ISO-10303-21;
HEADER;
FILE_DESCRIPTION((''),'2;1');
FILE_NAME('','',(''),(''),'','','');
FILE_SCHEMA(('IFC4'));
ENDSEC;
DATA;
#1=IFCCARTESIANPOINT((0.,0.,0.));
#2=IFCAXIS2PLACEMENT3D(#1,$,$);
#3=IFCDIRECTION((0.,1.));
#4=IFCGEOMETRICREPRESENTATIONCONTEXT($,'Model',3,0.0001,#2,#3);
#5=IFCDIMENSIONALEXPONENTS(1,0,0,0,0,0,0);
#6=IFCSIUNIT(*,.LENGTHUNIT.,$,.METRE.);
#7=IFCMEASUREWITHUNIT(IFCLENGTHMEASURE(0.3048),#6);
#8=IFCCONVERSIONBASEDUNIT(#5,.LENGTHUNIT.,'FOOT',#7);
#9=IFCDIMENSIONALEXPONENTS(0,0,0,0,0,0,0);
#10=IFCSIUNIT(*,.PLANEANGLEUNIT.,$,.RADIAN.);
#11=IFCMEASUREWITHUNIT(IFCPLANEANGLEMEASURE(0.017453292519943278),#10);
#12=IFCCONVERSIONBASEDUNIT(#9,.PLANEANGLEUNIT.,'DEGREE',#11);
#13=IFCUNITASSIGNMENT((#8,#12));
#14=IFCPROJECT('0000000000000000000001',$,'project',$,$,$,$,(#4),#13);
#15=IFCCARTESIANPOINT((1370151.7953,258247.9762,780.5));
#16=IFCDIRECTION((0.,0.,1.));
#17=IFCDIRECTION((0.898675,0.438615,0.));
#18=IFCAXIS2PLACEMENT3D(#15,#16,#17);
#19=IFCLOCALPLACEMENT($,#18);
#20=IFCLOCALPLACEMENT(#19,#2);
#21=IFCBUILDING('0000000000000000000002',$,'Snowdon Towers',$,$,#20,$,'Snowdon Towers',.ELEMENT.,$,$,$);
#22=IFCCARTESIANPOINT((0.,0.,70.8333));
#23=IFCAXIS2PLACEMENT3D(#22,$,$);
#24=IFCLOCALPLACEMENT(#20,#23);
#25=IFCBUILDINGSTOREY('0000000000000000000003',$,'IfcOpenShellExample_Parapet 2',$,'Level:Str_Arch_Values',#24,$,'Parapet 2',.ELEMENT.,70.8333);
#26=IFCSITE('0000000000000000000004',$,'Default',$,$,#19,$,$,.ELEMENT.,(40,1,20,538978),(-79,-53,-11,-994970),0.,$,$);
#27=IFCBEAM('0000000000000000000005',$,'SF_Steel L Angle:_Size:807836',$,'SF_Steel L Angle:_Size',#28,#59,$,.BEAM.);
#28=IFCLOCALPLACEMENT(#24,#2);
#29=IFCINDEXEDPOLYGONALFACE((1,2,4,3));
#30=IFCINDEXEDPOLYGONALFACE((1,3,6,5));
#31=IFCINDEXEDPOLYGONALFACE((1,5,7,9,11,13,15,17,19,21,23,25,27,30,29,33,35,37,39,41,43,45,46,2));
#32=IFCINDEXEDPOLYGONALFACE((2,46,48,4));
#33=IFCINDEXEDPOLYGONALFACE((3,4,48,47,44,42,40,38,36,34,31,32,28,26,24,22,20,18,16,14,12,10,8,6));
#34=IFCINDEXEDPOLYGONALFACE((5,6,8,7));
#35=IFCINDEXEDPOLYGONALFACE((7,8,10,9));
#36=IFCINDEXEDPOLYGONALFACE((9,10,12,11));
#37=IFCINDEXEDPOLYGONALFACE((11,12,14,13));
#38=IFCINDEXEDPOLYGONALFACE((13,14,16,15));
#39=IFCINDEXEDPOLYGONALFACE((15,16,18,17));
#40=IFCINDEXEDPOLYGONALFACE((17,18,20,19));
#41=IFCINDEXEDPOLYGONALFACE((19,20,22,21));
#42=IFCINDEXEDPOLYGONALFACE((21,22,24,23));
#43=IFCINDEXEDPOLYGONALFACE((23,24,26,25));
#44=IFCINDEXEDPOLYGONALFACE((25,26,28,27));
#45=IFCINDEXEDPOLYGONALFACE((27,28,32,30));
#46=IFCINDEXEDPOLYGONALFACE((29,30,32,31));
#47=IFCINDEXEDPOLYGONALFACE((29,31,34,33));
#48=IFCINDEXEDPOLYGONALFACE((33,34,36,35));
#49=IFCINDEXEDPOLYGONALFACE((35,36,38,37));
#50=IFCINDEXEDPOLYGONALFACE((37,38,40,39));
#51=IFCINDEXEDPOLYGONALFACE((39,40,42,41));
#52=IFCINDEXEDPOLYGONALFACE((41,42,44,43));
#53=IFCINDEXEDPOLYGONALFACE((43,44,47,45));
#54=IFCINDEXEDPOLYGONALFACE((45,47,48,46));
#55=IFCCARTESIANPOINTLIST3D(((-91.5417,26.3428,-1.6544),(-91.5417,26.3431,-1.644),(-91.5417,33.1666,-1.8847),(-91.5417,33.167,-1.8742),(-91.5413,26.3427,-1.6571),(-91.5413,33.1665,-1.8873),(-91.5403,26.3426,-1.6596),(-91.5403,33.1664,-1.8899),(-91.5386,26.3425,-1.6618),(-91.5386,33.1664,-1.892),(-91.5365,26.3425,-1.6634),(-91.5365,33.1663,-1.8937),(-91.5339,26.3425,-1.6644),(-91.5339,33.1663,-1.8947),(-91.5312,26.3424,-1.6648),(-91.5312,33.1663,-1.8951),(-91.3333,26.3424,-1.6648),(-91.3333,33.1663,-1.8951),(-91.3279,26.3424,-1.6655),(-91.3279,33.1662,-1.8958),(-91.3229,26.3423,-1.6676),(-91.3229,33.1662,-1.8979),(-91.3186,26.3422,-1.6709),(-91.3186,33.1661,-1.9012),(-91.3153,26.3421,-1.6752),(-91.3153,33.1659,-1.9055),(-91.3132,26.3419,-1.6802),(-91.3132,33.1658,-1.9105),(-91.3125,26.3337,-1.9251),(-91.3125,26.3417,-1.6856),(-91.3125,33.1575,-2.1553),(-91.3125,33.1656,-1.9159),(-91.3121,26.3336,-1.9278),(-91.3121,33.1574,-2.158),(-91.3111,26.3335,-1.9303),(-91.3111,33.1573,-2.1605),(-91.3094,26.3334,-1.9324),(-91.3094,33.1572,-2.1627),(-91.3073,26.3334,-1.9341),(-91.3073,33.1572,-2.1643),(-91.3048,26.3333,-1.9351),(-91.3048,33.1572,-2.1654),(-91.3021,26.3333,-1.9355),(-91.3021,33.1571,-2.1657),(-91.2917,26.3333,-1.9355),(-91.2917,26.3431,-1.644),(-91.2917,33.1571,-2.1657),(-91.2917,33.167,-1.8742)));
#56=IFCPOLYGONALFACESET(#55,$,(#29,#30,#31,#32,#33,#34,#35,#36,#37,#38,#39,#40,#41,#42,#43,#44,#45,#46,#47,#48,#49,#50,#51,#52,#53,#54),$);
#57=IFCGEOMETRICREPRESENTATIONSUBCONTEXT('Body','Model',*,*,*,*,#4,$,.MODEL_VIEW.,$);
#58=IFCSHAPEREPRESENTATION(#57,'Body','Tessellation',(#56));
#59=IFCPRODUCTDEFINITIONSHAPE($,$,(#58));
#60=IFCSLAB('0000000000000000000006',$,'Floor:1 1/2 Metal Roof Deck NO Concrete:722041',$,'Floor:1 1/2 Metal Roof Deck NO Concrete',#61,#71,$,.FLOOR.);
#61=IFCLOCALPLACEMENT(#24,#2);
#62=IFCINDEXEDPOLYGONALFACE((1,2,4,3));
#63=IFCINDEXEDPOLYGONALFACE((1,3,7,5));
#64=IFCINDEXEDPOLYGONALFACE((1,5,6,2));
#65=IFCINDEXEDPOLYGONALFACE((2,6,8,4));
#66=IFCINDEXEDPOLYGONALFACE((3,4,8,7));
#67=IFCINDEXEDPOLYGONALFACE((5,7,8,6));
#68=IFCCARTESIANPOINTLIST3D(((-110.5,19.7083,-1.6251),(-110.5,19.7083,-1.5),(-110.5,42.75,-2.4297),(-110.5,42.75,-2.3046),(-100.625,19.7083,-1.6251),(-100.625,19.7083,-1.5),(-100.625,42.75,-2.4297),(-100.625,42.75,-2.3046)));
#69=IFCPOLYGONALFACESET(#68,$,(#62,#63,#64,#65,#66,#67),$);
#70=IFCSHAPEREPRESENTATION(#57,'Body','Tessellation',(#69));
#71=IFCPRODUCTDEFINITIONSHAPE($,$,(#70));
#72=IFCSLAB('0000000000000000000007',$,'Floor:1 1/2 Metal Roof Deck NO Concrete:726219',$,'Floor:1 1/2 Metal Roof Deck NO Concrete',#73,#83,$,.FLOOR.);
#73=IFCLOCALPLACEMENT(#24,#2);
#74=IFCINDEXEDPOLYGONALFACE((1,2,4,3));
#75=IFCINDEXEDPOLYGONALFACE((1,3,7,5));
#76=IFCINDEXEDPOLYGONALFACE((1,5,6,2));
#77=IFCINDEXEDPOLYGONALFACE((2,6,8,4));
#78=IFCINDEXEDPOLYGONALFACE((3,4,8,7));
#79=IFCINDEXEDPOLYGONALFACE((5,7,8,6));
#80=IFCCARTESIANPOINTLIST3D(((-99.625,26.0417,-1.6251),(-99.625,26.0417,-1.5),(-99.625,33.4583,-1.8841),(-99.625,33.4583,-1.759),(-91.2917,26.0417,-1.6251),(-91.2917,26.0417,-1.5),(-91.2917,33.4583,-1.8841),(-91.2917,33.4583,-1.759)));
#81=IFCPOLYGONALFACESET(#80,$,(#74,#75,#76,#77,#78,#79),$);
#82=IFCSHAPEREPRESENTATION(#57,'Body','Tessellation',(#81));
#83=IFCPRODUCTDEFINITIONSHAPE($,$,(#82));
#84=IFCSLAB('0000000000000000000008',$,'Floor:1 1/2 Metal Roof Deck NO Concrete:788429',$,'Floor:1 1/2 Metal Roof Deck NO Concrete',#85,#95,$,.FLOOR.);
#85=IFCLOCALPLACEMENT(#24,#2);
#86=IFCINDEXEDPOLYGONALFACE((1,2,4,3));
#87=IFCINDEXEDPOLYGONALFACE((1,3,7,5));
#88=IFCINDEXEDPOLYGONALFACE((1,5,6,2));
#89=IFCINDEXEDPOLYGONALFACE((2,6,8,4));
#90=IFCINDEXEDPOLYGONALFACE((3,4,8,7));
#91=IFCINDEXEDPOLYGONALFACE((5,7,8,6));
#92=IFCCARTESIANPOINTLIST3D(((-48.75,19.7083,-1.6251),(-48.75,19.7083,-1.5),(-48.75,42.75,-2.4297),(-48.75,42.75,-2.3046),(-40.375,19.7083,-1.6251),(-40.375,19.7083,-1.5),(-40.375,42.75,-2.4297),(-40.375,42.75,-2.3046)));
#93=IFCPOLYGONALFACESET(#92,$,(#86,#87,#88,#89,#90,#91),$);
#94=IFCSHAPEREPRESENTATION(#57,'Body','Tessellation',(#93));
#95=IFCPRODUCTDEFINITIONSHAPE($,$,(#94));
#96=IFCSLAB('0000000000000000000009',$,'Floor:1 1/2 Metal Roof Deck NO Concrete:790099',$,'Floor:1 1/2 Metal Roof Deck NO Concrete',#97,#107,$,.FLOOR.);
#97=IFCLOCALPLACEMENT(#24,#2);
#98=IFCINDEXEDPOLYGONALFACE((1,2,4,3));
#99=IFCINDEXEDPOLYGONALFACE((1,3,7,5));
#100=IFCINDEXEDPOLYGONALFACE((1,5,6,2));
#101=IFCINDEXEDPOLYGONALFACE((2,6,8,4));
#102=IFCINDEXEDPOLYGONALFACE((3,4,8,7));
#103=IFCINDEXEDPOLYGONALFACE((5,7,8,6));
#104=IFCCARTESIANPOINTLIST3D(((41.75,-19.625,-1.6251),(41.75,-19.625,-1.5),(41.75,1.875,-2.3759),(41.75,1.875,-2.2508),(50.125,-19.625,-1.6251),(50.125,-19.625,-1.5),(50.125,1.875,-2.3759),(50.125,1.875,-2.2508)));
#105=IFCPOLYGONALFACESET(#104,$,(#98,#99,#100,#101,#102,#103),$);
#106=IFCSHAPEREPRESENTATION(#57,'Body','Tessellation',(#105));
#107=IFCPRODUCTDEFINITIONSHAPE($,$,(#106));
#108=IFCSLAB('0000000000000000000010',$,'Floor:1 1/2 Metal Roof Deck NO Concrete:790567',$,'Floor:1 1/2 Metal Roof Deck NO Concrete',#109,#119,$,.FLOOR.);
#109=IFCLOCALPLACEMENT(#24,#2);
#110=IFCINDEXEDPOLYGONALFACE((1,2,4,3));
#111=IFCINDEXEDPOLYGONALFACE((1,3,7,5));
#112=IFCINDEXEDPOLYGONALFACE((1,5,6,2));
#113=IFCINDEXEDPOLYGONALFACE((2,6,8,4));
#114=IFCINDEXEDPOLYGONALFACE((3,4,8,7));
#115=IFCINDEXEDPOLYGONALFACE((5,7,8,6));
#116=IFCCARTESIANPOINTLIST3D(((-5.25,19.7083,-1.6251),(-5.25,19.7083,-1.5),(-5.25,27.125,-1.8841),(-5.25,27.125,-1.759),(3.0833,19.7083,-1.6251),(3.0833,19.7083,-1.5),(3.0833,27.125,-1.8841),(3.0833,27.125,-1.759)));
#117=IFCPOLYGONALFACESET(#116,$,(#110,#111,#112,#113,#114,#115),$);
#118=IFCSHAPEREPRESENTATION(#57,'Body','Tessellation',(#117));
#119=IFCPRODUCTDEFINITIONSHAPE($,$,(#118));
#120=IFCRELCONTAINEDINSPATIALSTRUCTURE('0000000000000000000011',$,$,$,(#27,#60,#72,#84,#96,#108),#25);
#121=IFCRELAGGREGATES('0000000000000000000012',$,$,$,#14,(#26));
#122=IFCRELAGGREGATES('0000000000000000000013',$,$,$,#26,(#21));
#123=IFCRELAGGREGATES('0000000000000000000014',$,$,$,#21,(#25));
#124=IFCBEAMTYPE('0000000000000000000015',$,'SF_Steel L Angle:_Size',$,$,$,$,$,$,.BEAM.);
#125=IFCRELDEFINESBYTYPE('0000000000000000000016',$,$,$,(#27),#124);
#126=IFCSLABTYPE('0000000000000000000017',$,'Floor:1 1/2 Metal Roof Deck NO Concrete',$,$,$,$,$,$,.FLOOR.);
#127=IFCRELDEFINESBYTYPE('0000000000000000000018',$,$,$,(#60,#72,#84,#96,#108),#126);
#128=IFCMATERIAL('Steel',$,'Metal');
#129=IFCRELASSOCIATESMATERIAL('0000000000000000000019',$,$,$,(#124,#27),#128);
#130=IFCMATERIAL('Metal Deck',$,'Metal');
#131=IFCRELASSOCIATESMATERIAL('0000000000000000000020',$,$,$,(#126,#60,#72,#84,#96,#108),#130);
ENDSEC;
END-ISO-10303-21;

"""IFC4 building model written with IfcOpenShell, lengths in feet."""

from ifc_helpers import new_model, entity, si_unit, converted_unit, direction, frame, frame_2d, origin, place, context, subcontext, project, spatial, line, arc, indexed_curve, rectangle, outline, extrude, source, transform, mapped, material, type_object, type_shapes, element, save


model = new_model("IFC4")

# Units and contexts
model_context = context("Model", 3, precision=0.0001, world=origin(), true_north=direction((0.0, 1.0)))
body_context = subcontext(model_context, "Body", "Model", "MODEL_VIEW")
ifc_project = project(units=[converted_unit("LENGTHUNIT", "FOOT", entity("IfcLengthMeasure", 0.3048), si_unit("LENGTHUNIT", "METRE"), dimensions=[1, 0, 0, 0, 0, 0, 0]), converted_unit("PLANEANGLEUNIT", "DEGREE", entity("IfcPlaneAngleMeasure", 0.017453292519943278), si_unit("PLANEANGLEUNIT", "RADIAN"), dimensions=[0, 0, 0, 0, 0, 0, 0])], contexts=[model_context])

# Site, building, storey
site_placement = place(None, frame((1370151.7953, 258247.9762, 780.5), z_axis=(0.0, 0.0, 1.0), x_axis=(0.898675, 0.438615, 0.0)))
site = spatial("IfcSite", under=ifc_project, at=site_placement, Name="Default", CompositionType="ELEMENT", RefLatitude=(40, 1, 20, 538978), RefLongitude=(-79, -53, -11, -994970), RefElevation=0.0)
building_placement = place(site_placement, origin())
building = spatial("IfcBuilding", under=site, at=building_placement, Name="Snowdon Towers", LongName="Snowdon Towers", CompositionType="ELEMENT")
storey_placement = place(building_placement, frame((0.0, 0.0, 70.8333)))
storey = spatial("IfcBuildingStorey", under=building, at=storey_placement, Name="IfcOpenShellExample_Parapet 2", ObjectType="Level:Str_Arch_Values", LongName="Parapet 2", CompositionType="ELEMENT", Elevation=70.8333)

# Beam
ifc_material_1 = material(Name="Steel", Category="Metal")
beam_type_1 = type_object("IfcBeamType", Name="SF_Steel L Angle:_Size", PredefinedType="BEAM", material=ifc_material_1)
shared_shape_1 = source(origin(), body_context, "Body", "SweptSolid", [
    extrude(outline(indexed_curve([(-0.0926, -0.1065), (0.1574, -0.1065), (0.1574, -0.0961), (0.1544, -0.0887), (0.147, -0.0856), (-0.0509, -0.0856), (-0.0657, -0.0795), (-0.0718, -0.0648), (-0.0718, 0.1748), (-0.0748, 0.1821), (-0.0822, 0.1852), (-0.0926, 0.1852)], segments=[line(1, 2, 3), arc(3, 4, 5), line(5, 6), arc(6, 7, 8), line(8, 9), arc(9, 10, 11), line(11, 12, 1)], self_intersect=False)), frame((-3.4189, -0.0926, -0.1065), z_axis=(1.0, 0.0, 0.0), x_axis=(0.0, -1.0, 0.0)), (0.0, 0.0, 1.0), 6.8277),
])
type_shapes(beam_type_1, [shared_shape_1])
beam_1_placement = place(storey_placement, frame((-91.2917, 29.75, -1.7589), z_axis=(0.0, 0.033724, 0.999431), x_axis=(0.0, -0.999431, 0.033724)))
element("IfcBeam", 1, at=beam_1_placement, inside=storey, type_object=beam_type_1, material=ifc_material_1, Name="SF_Steel L Angle:_Size:807836", ObjectType="SF_Steel L Angle:_Size", PredefinedType="BEAM", context=body_context, shape_type="MappedRepresentation", body=[
    mapped(shared_shape_1, transform((0.0, 0.0, 0.0), scale=1.0)),
])

# Slabs
ifc_material_2 = material(Name="Metal Deck", Category="Metal")
slab_type = type_object("IfcSlabType", Name="Floor:1 1/2 Metal Roof Deck NO Concrete", PredefinedType="FLOOR", material=ifc_material_2)
slab_1_placement = place(storey_placement, frame((-110.5, 19.7083, -2.4297)))
element("IfcSlab", 2, at=slab_1_placement, inside=storey, type_object=slab_type, material=ifc_material_2, Name="Floor:1 1/2 Metal Roof Deck NO Concrete:722041", ObjectType="Floor:1 1/2 Metal Roof Deck NO Concrete", PredefinedType="FLOOR", context=body_context, shape_type="SweptSolid", body=[
    extrude(rectangle(XDim=23.0557, YDim=9.875, at=frame_2d((-4.9375, 11.5279), x_axis=(0.0, 1.0))), frame((9.875, 0.0, 0.9297), z_axis=(0.0, 0.034899, 0.999391), x_axis=(1.0, 0.0, 0.0)), (0.0, 0.034899, -0.999391), 0.1251),
])
slab_2_placement = place(storey_placement, frame((-99.625, 26.0417, -1.8841)))
element("IfcSlab", 3, at=slab_2_placement, inside=storey, type_object=slab_type, material=ifc_material_2, Name="Floor:1 1/2 Metal Roof Deck NO Concrete:726219", ObjectType="Floor:1 1/2 Metal Roof Deck NO Concrete", PredefinedType="FLOOR", context=body_context, shape_type="SweptSolid", body=[
    extrude(rectangle(XDim=7.4212, YDim=8.3333, at=frame_2d((-4.1667, 3.7106), x_axis=(0.0, -1.0))), frame((8.3333, 0.0, 0.3841), z_axis=(0.0, 0.034899, 0.999391), x_axis=(1.0, 0.0, 0.0)), (0.0, 0.034899, -0.999391), 0.1251),
])
slab_3_placement = place(storey_placement, frame((-48.75, 19.7083, -2.4297)))
element("IfcSlab", 4, at=slab_3_placement, inside=storey, type_object=slab_type, material=ifc_material_2, Name="Floor:1 1/2 Metal Roof Deck NO Concrete:788429", ObjectType="Floor:1 1/2 Metal Roof Deck NO Concrete", PredefinedType="FLOOR", context=body_context, shape_type="SweptSolid", body=[
    extrude(rectangle(XDim=8.375, YDim=23.0557, at=frame_2d((-4.1875, 11.5279), x_axis=(1.0, 0.0))), frame((8.375, 0.0, 0.9297), z_axis=(0.0, 0.034899, 0.999391), x_axis=(1.0, 0.0, 0.0)), (0.0, 0.034899, -0.999391), 0.1251),
])
slab_4_placement = place(storey_placement, frame((41.75, -19.625, -2.3759)))
element("IfcSlab", 5, at=slab_4_placement, inside=storey, type_object=slab_type, material=ifc_material_2, Name="Floor:1 1/2 Metal Roof Deck NO Concrete:790099", ObjectType="Floor:1 1/2 Metal Roof Deck NO Concrete", PredefinedType="FLOOR", context=body_context, shape_type="SweptSolid", body=[
    extrude(rectangle(XDim=8.375, YDim=21.5131, at=frame_2d((-4.1875, 10.7566), x_axis=(1.0, 0.0))), frame((8.375, 0.0, 0.8759), z_axis=(0.0, 0.034899, 0.999391), x_axis=(1.0, 0.0, 0.0)), (0.0, 0.034899, -0.999391), 0.1251),
])
slab_5_placement = place(storey_placement, frame((-5.25, 19.7083, -1.8841)))
element("IfcSlab", 6, at=slab_5_placement, inside=storey, type_object=slab_type, material=ifc_material_2, Name="Floor:1 1/2 Metal Roof Deck NO Concrete:790567", ObjectType="Floor:1 1/2 Metal Roof Deck NO Concrete", PredefinedType="FLOOR", context=body_context, shape_type="SweptSolid", body=[
    extrude(rectangle(XDim=7.4212, YDim=8.3333, at=frame_2d((-4.1667, 3.7106), x_axis=(0.0, -1.0))), frame((8.3333, 0.0, 0.3841), z_axis=(0.0, 0.034899, 0.999391), x_axis=(1.0, 0.0, 0.0)), (0.0, 0.034899, -0.999391), 0.1251),
])

save(model, "model.ifc")
